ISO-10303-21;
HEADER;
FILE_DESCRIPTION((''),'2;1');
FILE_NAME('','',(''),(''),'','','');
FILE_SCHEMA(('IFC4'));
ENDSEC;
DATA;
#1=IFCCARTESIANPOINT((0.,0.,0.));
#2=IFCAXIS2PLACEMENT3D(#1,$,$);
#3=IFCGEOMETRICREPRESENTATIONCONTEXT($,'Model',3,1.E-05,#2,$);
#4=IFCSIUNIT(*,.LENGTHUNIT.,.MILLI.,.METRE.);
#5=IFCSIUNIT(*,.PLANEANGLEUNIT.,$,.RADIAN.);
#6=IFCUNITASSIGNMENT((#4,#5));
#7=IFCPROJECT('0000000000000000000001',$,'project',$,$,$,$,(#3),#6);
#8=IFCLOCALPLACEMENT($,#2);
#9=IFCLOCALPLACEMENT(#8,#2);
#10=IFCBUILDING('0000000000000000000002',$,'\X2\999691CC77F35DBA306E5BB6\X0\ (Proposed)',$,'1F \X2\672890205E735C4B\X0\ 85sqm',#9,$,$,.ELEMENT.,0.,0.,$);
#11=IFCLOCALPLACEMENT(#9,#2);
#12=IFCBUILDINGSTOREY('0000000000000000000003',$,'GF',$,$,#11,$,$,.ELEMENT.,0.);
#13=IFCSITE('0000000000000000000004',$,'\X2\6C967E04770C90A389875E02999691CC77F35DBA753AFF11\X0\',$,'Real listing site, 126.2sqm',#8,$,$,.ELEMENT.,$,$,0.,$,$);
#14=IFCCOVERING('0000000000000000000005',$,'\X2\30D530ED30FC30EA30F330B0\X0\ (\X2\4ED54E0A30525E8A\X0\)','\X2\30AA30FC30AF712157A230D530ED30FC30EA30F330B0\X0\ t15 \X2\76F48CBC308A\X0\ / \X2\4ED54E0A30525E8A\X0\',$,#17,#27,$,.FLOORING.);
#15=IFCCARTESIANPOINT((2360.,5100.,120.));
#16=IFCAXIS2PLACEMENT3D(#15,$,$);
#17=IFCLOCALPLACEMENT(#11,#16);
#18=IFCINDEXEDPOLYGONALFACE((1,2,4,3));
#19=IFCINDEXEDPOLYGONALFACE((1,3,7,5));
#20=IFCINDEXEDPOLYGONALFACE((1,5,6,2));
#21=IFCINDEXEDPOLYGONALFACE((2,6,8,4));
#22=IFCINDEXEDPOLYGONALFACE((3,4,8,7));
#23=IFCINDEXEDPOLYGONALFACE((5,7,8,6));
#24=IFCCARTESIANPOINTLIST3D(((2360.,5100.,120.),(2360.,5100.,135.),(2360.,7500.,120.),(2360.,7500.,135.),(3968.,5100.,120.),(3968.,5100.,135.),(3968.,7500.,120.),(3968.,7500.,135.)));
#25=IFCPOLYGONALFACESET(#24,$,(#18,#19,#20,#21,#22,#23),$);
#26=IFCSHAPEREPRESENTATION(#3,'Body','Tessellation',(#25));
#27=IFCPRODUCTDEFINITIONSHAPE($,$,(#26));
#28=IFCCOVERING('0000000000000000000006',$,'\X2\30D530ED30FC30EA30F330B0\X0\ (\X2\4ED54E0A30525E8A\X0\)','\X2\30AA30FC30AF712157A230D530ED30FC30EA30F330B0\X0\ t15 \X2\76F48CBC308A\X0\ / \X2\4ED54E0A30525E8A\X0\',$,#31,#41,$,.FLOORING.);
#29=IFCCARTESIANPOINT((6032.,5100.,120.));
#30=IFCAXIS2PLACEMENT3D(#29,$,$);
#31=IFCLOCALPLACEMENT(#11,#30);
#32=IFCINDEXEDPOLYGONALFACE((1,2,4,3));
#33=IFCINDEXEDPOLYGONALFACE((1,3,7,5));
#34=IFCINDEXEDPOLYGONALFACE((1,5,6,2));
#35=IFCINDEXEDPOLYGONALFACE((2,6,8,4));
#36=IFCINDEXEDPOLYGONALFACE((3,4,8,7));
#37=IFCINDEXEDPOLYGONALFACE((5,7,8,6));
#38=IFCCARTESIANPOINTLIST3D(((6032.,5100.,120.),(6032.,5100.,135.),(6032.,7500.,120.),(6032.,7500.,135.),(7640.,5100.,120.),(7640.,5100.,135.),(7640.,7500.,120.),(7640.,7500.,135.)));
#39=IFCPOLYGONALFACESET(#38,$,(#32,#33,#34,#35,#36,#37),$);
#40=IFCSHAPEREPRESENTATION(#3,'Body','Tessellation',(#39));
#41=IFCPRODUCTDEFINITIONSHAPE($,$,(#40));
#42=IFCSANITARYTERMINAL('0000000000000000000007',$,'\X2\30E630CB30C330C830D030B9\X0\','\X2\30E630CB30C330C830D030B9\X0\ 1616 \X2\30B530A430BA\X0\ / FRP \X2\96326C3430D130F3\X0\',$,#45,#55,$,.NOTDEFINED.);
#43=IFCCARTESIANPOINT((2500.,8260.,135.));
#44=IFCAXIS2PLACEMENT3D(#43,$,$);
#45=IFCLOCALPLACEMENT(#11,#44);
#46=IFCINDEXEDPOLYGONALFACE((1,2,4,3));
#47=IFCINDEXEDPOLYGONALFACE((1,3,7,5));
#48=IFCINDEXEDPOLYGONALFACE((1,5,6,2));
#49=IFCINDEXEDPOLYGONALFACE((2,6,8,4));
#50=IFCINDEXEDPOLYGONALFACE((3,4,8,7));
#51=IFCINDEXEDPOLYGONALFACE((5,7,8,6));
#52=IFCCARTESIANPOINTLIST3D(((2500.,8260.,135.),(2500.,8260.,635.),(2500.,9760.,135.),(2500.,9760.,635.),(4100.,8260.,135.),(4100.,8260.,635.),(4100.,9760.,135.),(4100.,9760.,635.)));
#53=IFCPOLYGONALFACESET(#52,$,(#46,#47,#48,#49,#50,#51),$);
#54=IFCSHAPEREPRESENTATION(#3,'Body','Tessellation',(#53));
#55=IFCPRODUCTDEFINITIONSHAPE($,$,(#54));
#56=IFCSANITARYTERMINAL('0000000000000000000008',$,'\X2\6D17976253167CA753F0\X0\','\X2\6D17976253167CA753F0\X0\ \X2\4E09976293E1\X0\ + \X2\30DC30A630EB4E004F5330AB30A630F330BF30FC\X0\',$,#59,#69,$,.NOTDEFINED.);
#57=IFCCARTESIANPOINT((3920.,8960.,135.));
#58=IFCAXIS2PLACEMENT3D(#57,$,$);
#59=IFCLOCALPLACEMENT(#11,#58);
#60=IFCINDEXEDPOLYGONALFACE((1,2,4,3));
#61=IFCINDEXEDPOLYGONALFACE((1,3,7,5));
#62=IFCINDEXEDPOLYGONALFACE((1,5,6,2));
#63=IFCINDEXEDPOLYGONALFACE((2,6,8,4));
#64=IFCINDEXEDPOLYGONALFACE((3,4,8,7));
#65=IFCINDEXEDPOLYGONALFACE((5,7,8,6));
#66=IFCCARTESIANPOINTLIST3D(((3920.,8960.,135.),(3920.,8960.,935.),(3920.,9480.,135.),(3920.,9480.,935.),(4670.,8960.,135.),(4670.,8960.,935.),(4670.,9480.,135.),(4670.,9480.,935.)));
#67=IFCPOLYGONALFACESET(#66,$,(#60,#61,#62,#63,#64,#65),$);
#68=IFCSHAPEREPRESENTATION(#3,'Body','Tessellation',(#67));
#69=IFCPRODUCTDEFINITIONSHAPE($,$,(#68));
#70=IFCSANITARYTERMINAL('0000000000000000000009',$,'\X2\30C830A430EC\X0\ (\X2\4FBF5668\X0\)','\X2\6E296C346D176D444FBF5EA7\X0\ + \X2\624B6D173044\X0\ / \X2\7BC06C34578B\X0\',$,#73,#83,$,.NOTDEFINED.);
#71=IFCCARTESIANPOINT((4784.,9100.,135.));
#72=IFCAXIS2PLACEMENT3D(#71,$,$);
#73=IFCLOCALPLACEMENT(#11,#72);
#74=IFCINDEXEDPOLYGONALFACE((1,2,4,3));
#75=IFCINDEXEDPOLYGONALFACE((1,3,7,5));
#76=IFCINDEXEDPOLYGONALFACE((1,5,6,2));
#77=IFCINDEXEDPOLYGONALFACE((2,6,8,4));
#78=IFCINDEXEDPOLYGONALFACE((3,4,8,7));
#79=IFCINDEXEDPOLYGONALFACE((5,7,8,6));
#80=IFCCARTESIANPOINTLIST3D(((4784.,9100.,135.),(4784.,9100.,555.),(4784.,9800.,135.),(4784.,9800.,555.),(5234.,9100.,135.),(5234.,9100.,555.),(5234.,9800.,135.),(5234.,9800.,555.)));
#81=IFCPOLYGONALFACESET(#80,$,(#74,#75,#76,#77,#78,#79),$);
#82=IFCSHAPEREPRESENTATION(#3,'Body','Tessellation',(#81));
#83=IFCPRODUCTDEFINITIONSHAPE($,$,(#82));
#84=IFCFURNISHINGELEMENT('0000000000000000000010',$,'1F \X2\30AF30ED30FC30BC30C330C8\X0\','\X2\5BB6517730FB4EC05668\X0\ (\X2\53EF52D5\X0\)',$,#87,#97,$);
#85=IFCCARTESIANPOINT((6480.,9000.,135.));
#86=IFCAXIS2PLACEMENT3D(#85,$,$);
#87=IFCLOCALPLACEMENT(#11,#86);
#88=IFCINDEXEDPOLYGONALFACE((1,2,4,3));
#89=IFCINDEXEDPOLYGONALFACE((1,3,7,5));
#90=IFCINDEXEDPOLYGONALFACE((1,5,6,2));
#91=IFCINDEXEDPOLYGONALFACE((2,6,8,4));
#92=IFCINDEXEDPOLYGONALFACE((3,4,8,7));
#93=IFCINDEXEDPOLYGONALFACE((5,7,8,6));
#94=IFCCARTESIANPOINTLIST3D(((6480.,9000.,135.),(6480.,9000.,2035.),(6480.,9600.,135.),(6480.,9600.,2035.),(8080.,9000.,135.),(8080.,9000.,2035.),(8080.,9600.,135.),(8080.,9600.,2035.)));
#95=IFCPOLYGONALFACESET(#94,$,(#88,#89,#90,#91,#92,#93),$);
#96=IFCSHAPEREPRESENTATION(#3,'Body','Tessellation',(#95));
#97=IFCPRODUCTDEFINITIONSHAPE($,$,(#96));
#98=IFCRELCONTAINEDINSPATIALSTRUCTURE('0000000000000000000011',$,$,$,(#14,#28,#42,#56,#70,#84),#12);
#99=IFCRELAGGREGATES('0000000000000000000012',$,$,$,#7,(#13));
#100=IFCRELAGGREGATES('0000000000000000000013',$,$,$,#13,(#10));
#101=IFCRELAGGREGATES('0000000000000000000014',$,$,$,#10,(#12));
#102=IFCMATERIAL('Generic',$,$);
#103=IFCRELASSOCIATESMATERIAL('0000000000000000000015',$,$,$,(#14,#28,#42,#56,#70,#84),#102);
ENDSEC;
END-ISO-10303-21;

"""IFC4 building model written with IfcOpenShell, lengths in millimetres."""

from ifc_helpers import new_model, si_unit, frame, frame_2d, origin, place, context, project, spatial, rectangle, extrude, material, element, save


model = new_model("IFC4")

# Units and contexts
model_context = context("Model", 3, precision=1e-05, world=origin())
ifc_project = project(units=[si_unit("LENGTHUNIT", "METRE", prefix="MILLI"), si_unit("PLANEANGLEUNIT", "RADIAN")], contexts=[model_context])

# Site, building, storey
site_placement = place(None, origin())
site = spatial("IfcSite", under=ifc_project, at=site_placement, Name="沖縄県那覇市首里石嶺町１", ObjectType="Real listing site, 126.2sqm", CompositionType="ELEMENT", RefElevation=0.0)
building_placement = place(site_placement, origin())
building = spatial("IfcBuilding", under=site, at=building_placement, Name="首里石嶺の家 (Proposed)", ObjectType="1F 木造平屋 85sqm", CompositionType="ELEMENT", ElevationOfRefHeight=0.0, ElevationOfTerrain=0.0)
storey_placement = place(building_placement, origin())
storey = spatial("IfcBuildingStorey", under=building, at=storey_placement, Name="GF", CompositionType="ELEMENT", Elevation=0.0)

# Coverings
ifc_material_1 = material(Name="Generic")
covering_1_placement = place(storey_placement, frame((2360.0, 5100.0, 120.0)))
element("IfcCovering", 1, at=covering_1_placement, inside=storey, material=ifc_material_1, Name="フローリング (仕上げ床)", Description="オーク無垢フローリング t15 直貼り / 仕上げ床", PredefinedType="FLOORING", context=model_context, shape_type="SweptSolid", body=[
    extrude(rectangle(XDim=1608.0, YDim=2400.0, at=frame_2d((804.0, 1200.0))), frame((2360.0, 5100.0, 120.0)), (0.0, 0.0, 1.0), 15.0),
])
covering_2_placement = place(storey_placement, frame((6032.0, 5100.0, 120.0)))
element("IfcCovering", 2, at=covering_2_placement, inside=storey, material=ifc_material_1, Name="フローリング (仕上げ床)", Description="オーク無垢フローリング t15 直貼り / 仕上げ床", PredefinedType="FLOORING", context=model_context, shape_type="SweptSolid", body=[
    extrude(rectangle(XDim=1608.0, YDim=2400.0, at=frame_2d((804.0, 1200.0))), frame((6032.0, 5100.0, 120.0)), (0.0, 0.0, 1.0), 15.0),
])

# Sanitary terminals
sanitary_terminal_1_placement = place(storey_placement, frame((2500.0, 8260.0, 135.0)))
element("IfcSanitaryTerminal", 3, at=sanitary_terminal_1_placement, inside=storey, material=ifc_material_1, Name="ユニットバス", Description="ユニットバス 1616 サイズ / FRP 防水パン", PredefinedType="NOTDEFINED", context=model_context, shape_type="SweptSolid", body=[
    extrude(rectangle(XDim=1600.0, YDim=1500.0, at=frame_2d((800.0, 750.0))), frame((2500.0, 8260.0, 135.0)), (0.0, 0.0, 1.0), 500.0),
])
sanitary_terminal_2_placement = place(storey_placement, frame((3920.0, 8960.0, 135.0)))
element("IfcSanitaryTerminal", 4, at=sanitary_terminal_2_placement, inside=storey, material=ifc_material_1, Name="洗面化粧台", Description="洗面化粧台 三面鏡 + ボウル一体カウンター", PredefinedType="NOTDEFINED", context=model_context, shape_type="SweptSolid", body=[
    extrude(rectangle(XDim=750.0, YDim=520.0, at=frame_2d((375.0, 260.0))), frame((3920.0, 8960.0, 135.0)), (0.0, 0.0, 1.0), 800.0),
])
sanitary_terminal_3_placement = place(storey_placement, frame((4784.0, 9100.0, 135.0)))
element("IfcSanitaryTerminal", 5, at=sanitary_terminal_3_placement, inside=storey, material=ifc_material_1, Name="トイレ (便器)", Description="温水洗浄便座 + 手洗い / 節水型", PredefinedType="NOTDEFINED", context=model_context, shape_type="SweptSolid", body=[
    extrude(rectangle(XDim=450.0, YDim=700.0, at=frame_2d((225.0, 350.0))), frame((4784.0, 9100.0, 135.0)), (0.0, 0.0, 1.0), 420.0),
])

# Furnishing element
furnishing_placement = place(storey_placement, frame((6480.0, 9000.0, 135.0)))
element("IfcFurnishingElement", 6, at=furnishing_placement, inside=storey, material=ifc_material_1, Name="1F クローゼット", Description="家具・什器 (可動)", context=model_context, shape_type="SweptSolid", body=[
    extrude(rectangle(XDim=1600.0, YDim=600.0, at=frame_2d((800.0, 300.0))), frame((6480.0, 9000.0, 135.0)), (0.0, 0.0, 1.0), 1900.0),
])

save(model, "model.ifc")
